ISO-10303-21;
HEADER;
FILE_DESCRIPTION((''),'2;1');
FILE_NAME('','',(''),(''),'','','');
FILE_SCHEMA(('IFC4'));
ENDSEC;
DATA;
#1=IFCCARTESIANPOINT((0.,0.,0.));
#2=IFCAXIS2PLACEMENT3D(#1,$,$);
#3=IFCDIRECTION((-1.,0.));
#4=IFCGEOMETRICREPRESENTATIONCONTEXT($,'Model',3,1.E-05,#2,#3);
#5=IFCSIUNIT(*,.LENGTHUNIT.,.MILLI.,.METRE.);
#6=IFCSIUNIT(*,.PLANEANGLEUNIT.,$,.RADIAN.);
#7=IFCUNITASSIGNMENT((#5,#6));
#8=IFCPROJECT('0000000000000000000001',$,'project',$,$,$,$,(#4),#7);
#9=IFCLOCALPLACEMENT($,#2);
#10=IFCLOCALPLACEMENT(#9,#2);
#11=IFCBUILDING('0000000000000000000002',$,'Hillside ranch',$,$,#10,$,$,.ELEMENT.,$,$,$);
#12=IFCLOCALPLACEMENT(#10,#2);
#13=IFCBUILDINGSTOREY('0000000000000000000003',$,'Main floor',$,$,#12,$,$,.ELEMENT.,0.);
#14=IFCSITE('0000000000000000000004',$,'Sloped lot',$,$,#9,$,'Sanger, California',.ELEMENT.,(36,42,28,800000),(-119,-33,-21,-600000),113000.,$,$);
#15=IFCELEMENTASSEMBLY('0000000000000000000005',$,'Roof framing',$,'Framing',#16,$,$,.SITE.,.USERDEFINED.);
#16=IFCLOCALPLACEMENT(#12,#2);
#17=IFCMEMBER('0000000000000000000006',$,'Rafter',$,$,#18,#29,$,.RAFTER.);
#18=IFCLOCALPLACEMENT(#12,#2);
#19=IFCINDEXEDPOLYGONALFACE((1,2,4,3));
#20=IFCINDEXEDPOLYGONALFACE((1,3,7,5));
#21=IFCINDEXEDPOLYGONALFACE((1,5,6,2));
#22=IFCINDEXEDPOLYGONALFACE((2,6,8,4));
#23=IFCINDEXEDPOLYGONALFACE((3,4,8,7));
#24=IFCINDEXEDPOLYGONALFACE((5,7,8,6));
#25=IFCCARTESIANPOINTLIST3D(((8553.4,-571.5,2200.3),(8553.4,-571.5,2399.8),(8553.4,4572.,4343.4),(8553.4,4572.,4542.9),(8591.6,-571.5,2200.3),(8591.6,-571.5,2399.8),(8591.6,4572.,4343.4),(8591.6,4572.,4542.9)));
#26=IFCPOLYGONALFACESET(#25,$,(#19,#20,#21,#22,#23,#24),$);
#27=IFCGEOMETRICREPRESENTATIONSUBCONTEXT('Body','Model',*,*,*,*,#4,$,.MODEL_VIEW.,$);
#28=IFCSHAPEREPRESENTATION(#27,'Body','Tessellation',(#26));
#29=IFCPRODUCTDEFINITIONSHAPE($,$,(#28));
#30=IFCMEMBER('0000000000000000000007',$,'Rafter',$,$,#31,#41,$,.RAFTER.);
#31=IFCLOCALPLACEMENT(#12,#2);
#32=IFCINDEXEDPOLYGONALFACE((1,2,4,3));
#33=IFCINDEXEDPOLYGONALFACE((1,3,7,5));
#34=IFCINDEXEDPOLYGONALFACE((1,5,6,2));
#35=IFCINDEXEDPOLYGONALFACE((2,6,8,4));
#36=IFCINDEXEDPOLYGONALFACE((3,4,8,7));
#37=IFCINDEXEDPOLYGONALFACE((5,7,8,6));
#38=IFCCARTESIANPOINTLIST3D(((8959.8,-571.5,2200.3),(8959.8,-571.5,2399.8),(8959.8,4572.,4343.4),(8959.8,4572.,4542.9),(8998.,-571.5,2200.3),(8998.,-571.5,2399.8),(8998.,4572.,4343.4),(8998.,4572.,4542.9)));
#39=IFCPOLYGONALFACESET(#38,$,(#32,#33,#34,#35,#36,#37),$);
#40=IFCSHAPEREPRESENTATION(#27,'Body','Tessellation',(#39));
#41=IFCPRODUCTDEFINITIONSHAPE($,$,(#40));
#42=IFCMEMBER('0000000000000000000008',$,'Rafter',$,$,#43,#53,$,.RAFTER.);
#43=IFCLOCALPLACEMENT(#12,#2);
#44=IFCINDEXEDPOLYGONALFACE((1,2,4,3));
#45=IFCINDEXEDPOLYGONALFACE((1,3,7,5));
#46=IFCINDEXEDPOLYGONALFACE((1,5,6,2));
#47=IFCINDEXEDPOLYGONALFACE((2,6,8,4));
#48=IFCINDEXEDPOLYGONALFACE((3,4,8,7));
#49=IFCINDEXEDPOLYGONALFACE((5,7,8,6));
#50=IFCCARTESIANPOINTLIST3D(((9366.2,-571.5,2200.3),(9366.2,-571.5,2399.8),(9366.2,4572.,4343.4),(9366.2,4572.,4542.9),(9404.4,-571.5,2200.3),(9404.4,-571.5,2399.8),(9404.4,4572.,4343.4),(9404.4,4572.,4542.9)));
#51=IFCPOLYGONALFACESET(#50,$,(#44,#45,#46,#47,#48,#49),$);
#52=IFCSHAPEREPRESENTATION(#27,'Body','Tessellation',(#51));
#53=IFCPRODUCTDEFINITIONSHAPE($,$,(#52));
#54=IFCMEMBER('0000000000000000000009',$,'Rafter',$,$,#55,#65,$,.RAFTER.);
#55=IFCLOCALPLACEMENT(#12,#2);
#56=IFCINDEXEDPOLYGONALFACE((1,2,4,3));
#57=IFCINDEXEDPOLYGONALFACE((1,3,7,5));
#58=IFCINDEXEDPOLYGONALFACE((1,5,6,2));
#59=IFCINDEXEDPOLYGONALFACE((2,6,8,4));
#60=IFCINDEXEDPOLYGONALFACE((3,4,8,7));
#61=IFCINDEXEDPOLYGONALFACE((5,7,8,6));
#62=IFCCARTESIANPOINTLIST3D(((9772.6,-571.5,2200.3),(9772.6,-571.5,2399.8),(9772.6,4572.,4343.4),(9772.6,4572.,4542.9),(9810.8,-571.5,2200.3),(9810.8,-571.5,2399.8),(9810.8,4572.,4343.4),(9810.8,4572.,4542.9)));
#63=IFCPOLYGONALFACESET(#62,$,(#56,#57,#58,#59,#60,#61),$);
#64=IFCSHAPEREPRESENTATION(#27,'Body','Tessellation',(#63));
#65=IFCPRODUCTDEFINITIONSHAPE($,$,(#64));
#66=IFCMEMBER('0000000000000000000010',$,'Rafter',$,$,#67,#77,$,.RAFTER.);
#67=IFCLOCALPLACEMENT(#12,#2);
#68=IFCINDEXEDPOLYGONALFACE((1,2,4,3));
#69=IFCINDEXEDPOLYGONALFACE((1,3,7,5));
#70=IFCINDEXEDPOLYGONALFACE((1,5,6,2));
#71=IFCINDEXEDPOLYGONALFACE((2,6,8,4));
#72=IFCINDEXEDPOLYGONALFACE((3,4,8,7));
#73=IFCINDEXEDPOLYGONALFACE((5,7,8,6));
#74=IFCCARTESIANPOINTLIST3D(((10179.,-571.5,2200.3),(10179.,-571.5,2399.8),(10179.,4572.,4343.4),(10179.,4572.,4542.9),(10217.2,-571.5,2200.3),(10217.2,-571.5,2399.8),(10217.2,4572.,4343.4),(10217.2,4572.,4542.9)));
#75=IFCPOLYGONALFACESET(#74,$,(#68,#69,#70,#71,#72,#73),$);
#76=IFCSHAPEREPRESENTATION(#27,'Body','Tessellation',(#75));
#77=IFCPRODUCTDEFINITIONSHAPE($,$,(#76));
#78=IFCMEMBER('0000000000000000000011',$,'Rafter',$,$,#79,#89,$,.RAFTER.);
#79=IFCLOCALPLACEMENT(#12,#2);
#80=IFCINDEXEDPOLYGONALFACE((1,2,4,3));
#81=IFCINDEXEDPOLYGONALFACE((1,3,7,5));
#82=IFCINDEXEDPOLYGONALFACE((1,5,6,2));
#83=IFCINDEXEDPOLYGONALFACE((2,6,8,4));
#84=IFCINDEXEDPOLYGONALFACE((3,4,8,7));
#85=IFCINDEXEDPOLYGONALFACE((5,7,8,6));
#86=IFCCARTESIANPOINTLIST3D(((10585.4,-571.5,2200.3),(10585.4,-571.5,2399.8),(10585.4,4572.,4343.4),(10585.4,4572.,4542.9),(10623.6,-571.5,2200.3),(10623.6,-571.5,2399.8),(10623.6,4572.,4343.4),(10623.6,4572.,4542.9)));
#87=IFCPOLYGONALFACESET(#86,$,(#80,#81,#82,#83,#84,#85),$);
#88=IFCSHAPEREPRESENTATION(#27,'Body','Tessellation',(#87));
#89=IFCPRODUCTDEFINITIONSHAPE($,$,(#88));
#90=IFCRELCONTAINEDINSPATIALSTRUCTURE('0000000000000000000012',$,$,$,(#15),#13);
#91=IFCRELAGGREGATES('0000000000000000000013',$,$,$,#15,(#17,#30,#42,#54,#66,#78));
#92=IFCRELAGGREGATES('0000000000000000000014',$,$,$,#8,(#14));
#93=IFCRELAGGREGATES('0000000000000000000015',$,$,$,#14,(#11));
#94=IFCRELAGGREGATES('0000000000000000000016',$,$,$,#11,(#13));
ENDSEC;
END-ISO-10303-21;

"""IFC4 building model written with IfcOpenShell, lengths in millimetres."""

from ifc_helpers import new_model, si_unit, direction, frame, origin, origin_with_axes, place, context, subcontext, project, spatial, polyline, outline, extrude, element, aggregate, save


model = new_model("IFC4")

# Units and contexts
model_context = context("Model", 3, precision=1e-05, world=origin(), true_north=direction((-1.0, 0.0)))
body_context = subcontext(model_context, "Body", "Model", "MODEL_VIEW")
ifc_project = project(units=[si_unit("LENGTHUNIT", "METRE", prefix="MILLI"), si_unit("PLANEANGLEUNIT", "RADIAN")], contexts=[model_context])

# Site, building, storey
site_placement = place(None, origin())
site = spatial("IfcSite", under=ifc_project, at=site_placement, Name="Sloped lot", LongName="Sanger, California", CompositionType="ELEMENT", RefLatitude=(36, 42, 28, 800000), RefLongitude=(-119, -33, -21, -600000), RefElevation=113000.0)
building_placement = place(site_placement, origin())
building = spatial("IfcBuilding", under=site, at=building_placement, Name="Hillside ranch", CompositionType="ELEMENT")
storey_placement = place(building_placement, origin())
storey = spatial("IfcBuildingStorey", under=building, at=storey_placement, Name="Main floor", CompositionType="ELEMENT", Elevation=0.0)

# Element assembly, members
assembly_placement = place(storey_placement, origin_with_axes())
assembly = element("IfcElementAssembly", 1, at=assembly_placement, inside=storey, Name="Roof framing", ObjectType="Framing", AssemblyPlace="SITE", PredefinedType="USERDEFINED")
member_1_placement = place(storey_placement, origin_with_axes())
member_1 = element("IfcMember", 2, at=member_1_placement, Name="Rafter", PredefinedType="RAFTER", context=body_context, shape_type="SweptSolid", body=[
    extrude(outline(polyline([(0.0, 0.0), (38.1, 0.0), (38.1, 199.5), (0.0, 199.5), (0.0, 0.0)])), frame((8591.5, -571.5, 2200.3), z_axis=(0.0, 1.0, 0.0), x_axis=(-1.0, 0.0, 0.0)), (0.0, 0.384615, 0.923077), 5572.1),
])
member_2_placement = place(storey_placement, origin_with_axes())
member_2 = element("IfcMember", 3, at=member_2_placement, Name="Rafter", PredefinedType="RAFTER", context=body_context, shape_type="SweptSolid", body=[
    extrude(outline(polyline([(0.0, 0.0), (38.1, 0.0), (38.1, 199.5), (0.0, 199.5), (0.0, 0.0)])), frame((8998.0, -571.5, 2200.3), z_axis=(0.0, 1.0, 0.0), x_axis=(-1.0, 0.0, 0.0)), (0.0, 0.384615, 0.923077), 5572.1),
])
member_3_placement = place(storey_placement, origin_with_axes())
member_3 = element("IfcMember", 4, at=member_3_placement, Name="Rafter", PredefinedType="RAFTER", context=body_context, shape_type="SweptSolid", body=[
    extrude(outline(polyline([(0.0, 0.0), (38.1, 0.0), (38.1, 199.5), (0.0, 199.5), (0.0, 0.0)])), frame((9404.4, -571.5, 2200.3), z_axis=(0.0, 1.0, 0.0), x_axis=(-1.0, 0.0, 0.0)), (0.0, 0.384615, 0.923077), 5572.1),
])
member_4_placement = place(storey_placement, origin_with_axes())
member_4 = element("IfcMember", 5, at=member_4_placement, Name="Rafter", PredefinedType="RAFTER", context=body_context, shape_type="SweptSolid", body=[
    extrude(outline(polyline([(0.0, 0.0), (38.1, 0.0), (38.1, 199.5), (0.0, 199.5), (0.0, 0.0)])), frame((9810.8, -571.5, 2200.3), z_axis=(0.0, 1.0, 0.0), x_axis=(-1.0, 0.0, 0.0)), (0.0, 0.384615, 0.923077), 5572.1),
])
member_5_placement = place(storey_placement, origin_with_axes())
member_5 = element("IfcMember", 6, at=member_5_placement, Name="Rafter", PredefinedType="RAFTER", context=body_context, shape_type="SweptSolid", body=[
    extrude(outline(polyline([(0.0, 0.0), (38.1, 0.0), (38.1, 199.5), (0.0, 199.5), (0.0, 0.0)])), frame((10217.1, -571.5, 2200.3), z_axis=(0.0, 1.0, 0.0), x_axis=(-1.0, 0.0, 0.0)), (0.0, 0.384615, 0.923077), 5572.1),
])
member_6_placement = place(storey_placement, origin_with_axes())
member_6 = element("IfcMember", 7, at=member_6_placement, Name="Rafter", PredefinedType="RAFTER", context=body_context, shape_type="SweptSolid", body=[
    extrude(outline(polyline([(0.0, 0.0), (38.1, 0.0), (38.1, 199.5), (0.0, 199.5), (0.0, 0.0)])), frame((10623.5, -571.5, 2200.3), z_axis=(0.0, 1.0, 0.0), x_axis=(-1.0, 0.0, 0.0)), (0.0, 0.384615, 0.923077), 5572.1),
])
aggregate(assembly, [member_1, member_2, member_3, member_4, member_5, member_6])

save(model, "model.ifc")
